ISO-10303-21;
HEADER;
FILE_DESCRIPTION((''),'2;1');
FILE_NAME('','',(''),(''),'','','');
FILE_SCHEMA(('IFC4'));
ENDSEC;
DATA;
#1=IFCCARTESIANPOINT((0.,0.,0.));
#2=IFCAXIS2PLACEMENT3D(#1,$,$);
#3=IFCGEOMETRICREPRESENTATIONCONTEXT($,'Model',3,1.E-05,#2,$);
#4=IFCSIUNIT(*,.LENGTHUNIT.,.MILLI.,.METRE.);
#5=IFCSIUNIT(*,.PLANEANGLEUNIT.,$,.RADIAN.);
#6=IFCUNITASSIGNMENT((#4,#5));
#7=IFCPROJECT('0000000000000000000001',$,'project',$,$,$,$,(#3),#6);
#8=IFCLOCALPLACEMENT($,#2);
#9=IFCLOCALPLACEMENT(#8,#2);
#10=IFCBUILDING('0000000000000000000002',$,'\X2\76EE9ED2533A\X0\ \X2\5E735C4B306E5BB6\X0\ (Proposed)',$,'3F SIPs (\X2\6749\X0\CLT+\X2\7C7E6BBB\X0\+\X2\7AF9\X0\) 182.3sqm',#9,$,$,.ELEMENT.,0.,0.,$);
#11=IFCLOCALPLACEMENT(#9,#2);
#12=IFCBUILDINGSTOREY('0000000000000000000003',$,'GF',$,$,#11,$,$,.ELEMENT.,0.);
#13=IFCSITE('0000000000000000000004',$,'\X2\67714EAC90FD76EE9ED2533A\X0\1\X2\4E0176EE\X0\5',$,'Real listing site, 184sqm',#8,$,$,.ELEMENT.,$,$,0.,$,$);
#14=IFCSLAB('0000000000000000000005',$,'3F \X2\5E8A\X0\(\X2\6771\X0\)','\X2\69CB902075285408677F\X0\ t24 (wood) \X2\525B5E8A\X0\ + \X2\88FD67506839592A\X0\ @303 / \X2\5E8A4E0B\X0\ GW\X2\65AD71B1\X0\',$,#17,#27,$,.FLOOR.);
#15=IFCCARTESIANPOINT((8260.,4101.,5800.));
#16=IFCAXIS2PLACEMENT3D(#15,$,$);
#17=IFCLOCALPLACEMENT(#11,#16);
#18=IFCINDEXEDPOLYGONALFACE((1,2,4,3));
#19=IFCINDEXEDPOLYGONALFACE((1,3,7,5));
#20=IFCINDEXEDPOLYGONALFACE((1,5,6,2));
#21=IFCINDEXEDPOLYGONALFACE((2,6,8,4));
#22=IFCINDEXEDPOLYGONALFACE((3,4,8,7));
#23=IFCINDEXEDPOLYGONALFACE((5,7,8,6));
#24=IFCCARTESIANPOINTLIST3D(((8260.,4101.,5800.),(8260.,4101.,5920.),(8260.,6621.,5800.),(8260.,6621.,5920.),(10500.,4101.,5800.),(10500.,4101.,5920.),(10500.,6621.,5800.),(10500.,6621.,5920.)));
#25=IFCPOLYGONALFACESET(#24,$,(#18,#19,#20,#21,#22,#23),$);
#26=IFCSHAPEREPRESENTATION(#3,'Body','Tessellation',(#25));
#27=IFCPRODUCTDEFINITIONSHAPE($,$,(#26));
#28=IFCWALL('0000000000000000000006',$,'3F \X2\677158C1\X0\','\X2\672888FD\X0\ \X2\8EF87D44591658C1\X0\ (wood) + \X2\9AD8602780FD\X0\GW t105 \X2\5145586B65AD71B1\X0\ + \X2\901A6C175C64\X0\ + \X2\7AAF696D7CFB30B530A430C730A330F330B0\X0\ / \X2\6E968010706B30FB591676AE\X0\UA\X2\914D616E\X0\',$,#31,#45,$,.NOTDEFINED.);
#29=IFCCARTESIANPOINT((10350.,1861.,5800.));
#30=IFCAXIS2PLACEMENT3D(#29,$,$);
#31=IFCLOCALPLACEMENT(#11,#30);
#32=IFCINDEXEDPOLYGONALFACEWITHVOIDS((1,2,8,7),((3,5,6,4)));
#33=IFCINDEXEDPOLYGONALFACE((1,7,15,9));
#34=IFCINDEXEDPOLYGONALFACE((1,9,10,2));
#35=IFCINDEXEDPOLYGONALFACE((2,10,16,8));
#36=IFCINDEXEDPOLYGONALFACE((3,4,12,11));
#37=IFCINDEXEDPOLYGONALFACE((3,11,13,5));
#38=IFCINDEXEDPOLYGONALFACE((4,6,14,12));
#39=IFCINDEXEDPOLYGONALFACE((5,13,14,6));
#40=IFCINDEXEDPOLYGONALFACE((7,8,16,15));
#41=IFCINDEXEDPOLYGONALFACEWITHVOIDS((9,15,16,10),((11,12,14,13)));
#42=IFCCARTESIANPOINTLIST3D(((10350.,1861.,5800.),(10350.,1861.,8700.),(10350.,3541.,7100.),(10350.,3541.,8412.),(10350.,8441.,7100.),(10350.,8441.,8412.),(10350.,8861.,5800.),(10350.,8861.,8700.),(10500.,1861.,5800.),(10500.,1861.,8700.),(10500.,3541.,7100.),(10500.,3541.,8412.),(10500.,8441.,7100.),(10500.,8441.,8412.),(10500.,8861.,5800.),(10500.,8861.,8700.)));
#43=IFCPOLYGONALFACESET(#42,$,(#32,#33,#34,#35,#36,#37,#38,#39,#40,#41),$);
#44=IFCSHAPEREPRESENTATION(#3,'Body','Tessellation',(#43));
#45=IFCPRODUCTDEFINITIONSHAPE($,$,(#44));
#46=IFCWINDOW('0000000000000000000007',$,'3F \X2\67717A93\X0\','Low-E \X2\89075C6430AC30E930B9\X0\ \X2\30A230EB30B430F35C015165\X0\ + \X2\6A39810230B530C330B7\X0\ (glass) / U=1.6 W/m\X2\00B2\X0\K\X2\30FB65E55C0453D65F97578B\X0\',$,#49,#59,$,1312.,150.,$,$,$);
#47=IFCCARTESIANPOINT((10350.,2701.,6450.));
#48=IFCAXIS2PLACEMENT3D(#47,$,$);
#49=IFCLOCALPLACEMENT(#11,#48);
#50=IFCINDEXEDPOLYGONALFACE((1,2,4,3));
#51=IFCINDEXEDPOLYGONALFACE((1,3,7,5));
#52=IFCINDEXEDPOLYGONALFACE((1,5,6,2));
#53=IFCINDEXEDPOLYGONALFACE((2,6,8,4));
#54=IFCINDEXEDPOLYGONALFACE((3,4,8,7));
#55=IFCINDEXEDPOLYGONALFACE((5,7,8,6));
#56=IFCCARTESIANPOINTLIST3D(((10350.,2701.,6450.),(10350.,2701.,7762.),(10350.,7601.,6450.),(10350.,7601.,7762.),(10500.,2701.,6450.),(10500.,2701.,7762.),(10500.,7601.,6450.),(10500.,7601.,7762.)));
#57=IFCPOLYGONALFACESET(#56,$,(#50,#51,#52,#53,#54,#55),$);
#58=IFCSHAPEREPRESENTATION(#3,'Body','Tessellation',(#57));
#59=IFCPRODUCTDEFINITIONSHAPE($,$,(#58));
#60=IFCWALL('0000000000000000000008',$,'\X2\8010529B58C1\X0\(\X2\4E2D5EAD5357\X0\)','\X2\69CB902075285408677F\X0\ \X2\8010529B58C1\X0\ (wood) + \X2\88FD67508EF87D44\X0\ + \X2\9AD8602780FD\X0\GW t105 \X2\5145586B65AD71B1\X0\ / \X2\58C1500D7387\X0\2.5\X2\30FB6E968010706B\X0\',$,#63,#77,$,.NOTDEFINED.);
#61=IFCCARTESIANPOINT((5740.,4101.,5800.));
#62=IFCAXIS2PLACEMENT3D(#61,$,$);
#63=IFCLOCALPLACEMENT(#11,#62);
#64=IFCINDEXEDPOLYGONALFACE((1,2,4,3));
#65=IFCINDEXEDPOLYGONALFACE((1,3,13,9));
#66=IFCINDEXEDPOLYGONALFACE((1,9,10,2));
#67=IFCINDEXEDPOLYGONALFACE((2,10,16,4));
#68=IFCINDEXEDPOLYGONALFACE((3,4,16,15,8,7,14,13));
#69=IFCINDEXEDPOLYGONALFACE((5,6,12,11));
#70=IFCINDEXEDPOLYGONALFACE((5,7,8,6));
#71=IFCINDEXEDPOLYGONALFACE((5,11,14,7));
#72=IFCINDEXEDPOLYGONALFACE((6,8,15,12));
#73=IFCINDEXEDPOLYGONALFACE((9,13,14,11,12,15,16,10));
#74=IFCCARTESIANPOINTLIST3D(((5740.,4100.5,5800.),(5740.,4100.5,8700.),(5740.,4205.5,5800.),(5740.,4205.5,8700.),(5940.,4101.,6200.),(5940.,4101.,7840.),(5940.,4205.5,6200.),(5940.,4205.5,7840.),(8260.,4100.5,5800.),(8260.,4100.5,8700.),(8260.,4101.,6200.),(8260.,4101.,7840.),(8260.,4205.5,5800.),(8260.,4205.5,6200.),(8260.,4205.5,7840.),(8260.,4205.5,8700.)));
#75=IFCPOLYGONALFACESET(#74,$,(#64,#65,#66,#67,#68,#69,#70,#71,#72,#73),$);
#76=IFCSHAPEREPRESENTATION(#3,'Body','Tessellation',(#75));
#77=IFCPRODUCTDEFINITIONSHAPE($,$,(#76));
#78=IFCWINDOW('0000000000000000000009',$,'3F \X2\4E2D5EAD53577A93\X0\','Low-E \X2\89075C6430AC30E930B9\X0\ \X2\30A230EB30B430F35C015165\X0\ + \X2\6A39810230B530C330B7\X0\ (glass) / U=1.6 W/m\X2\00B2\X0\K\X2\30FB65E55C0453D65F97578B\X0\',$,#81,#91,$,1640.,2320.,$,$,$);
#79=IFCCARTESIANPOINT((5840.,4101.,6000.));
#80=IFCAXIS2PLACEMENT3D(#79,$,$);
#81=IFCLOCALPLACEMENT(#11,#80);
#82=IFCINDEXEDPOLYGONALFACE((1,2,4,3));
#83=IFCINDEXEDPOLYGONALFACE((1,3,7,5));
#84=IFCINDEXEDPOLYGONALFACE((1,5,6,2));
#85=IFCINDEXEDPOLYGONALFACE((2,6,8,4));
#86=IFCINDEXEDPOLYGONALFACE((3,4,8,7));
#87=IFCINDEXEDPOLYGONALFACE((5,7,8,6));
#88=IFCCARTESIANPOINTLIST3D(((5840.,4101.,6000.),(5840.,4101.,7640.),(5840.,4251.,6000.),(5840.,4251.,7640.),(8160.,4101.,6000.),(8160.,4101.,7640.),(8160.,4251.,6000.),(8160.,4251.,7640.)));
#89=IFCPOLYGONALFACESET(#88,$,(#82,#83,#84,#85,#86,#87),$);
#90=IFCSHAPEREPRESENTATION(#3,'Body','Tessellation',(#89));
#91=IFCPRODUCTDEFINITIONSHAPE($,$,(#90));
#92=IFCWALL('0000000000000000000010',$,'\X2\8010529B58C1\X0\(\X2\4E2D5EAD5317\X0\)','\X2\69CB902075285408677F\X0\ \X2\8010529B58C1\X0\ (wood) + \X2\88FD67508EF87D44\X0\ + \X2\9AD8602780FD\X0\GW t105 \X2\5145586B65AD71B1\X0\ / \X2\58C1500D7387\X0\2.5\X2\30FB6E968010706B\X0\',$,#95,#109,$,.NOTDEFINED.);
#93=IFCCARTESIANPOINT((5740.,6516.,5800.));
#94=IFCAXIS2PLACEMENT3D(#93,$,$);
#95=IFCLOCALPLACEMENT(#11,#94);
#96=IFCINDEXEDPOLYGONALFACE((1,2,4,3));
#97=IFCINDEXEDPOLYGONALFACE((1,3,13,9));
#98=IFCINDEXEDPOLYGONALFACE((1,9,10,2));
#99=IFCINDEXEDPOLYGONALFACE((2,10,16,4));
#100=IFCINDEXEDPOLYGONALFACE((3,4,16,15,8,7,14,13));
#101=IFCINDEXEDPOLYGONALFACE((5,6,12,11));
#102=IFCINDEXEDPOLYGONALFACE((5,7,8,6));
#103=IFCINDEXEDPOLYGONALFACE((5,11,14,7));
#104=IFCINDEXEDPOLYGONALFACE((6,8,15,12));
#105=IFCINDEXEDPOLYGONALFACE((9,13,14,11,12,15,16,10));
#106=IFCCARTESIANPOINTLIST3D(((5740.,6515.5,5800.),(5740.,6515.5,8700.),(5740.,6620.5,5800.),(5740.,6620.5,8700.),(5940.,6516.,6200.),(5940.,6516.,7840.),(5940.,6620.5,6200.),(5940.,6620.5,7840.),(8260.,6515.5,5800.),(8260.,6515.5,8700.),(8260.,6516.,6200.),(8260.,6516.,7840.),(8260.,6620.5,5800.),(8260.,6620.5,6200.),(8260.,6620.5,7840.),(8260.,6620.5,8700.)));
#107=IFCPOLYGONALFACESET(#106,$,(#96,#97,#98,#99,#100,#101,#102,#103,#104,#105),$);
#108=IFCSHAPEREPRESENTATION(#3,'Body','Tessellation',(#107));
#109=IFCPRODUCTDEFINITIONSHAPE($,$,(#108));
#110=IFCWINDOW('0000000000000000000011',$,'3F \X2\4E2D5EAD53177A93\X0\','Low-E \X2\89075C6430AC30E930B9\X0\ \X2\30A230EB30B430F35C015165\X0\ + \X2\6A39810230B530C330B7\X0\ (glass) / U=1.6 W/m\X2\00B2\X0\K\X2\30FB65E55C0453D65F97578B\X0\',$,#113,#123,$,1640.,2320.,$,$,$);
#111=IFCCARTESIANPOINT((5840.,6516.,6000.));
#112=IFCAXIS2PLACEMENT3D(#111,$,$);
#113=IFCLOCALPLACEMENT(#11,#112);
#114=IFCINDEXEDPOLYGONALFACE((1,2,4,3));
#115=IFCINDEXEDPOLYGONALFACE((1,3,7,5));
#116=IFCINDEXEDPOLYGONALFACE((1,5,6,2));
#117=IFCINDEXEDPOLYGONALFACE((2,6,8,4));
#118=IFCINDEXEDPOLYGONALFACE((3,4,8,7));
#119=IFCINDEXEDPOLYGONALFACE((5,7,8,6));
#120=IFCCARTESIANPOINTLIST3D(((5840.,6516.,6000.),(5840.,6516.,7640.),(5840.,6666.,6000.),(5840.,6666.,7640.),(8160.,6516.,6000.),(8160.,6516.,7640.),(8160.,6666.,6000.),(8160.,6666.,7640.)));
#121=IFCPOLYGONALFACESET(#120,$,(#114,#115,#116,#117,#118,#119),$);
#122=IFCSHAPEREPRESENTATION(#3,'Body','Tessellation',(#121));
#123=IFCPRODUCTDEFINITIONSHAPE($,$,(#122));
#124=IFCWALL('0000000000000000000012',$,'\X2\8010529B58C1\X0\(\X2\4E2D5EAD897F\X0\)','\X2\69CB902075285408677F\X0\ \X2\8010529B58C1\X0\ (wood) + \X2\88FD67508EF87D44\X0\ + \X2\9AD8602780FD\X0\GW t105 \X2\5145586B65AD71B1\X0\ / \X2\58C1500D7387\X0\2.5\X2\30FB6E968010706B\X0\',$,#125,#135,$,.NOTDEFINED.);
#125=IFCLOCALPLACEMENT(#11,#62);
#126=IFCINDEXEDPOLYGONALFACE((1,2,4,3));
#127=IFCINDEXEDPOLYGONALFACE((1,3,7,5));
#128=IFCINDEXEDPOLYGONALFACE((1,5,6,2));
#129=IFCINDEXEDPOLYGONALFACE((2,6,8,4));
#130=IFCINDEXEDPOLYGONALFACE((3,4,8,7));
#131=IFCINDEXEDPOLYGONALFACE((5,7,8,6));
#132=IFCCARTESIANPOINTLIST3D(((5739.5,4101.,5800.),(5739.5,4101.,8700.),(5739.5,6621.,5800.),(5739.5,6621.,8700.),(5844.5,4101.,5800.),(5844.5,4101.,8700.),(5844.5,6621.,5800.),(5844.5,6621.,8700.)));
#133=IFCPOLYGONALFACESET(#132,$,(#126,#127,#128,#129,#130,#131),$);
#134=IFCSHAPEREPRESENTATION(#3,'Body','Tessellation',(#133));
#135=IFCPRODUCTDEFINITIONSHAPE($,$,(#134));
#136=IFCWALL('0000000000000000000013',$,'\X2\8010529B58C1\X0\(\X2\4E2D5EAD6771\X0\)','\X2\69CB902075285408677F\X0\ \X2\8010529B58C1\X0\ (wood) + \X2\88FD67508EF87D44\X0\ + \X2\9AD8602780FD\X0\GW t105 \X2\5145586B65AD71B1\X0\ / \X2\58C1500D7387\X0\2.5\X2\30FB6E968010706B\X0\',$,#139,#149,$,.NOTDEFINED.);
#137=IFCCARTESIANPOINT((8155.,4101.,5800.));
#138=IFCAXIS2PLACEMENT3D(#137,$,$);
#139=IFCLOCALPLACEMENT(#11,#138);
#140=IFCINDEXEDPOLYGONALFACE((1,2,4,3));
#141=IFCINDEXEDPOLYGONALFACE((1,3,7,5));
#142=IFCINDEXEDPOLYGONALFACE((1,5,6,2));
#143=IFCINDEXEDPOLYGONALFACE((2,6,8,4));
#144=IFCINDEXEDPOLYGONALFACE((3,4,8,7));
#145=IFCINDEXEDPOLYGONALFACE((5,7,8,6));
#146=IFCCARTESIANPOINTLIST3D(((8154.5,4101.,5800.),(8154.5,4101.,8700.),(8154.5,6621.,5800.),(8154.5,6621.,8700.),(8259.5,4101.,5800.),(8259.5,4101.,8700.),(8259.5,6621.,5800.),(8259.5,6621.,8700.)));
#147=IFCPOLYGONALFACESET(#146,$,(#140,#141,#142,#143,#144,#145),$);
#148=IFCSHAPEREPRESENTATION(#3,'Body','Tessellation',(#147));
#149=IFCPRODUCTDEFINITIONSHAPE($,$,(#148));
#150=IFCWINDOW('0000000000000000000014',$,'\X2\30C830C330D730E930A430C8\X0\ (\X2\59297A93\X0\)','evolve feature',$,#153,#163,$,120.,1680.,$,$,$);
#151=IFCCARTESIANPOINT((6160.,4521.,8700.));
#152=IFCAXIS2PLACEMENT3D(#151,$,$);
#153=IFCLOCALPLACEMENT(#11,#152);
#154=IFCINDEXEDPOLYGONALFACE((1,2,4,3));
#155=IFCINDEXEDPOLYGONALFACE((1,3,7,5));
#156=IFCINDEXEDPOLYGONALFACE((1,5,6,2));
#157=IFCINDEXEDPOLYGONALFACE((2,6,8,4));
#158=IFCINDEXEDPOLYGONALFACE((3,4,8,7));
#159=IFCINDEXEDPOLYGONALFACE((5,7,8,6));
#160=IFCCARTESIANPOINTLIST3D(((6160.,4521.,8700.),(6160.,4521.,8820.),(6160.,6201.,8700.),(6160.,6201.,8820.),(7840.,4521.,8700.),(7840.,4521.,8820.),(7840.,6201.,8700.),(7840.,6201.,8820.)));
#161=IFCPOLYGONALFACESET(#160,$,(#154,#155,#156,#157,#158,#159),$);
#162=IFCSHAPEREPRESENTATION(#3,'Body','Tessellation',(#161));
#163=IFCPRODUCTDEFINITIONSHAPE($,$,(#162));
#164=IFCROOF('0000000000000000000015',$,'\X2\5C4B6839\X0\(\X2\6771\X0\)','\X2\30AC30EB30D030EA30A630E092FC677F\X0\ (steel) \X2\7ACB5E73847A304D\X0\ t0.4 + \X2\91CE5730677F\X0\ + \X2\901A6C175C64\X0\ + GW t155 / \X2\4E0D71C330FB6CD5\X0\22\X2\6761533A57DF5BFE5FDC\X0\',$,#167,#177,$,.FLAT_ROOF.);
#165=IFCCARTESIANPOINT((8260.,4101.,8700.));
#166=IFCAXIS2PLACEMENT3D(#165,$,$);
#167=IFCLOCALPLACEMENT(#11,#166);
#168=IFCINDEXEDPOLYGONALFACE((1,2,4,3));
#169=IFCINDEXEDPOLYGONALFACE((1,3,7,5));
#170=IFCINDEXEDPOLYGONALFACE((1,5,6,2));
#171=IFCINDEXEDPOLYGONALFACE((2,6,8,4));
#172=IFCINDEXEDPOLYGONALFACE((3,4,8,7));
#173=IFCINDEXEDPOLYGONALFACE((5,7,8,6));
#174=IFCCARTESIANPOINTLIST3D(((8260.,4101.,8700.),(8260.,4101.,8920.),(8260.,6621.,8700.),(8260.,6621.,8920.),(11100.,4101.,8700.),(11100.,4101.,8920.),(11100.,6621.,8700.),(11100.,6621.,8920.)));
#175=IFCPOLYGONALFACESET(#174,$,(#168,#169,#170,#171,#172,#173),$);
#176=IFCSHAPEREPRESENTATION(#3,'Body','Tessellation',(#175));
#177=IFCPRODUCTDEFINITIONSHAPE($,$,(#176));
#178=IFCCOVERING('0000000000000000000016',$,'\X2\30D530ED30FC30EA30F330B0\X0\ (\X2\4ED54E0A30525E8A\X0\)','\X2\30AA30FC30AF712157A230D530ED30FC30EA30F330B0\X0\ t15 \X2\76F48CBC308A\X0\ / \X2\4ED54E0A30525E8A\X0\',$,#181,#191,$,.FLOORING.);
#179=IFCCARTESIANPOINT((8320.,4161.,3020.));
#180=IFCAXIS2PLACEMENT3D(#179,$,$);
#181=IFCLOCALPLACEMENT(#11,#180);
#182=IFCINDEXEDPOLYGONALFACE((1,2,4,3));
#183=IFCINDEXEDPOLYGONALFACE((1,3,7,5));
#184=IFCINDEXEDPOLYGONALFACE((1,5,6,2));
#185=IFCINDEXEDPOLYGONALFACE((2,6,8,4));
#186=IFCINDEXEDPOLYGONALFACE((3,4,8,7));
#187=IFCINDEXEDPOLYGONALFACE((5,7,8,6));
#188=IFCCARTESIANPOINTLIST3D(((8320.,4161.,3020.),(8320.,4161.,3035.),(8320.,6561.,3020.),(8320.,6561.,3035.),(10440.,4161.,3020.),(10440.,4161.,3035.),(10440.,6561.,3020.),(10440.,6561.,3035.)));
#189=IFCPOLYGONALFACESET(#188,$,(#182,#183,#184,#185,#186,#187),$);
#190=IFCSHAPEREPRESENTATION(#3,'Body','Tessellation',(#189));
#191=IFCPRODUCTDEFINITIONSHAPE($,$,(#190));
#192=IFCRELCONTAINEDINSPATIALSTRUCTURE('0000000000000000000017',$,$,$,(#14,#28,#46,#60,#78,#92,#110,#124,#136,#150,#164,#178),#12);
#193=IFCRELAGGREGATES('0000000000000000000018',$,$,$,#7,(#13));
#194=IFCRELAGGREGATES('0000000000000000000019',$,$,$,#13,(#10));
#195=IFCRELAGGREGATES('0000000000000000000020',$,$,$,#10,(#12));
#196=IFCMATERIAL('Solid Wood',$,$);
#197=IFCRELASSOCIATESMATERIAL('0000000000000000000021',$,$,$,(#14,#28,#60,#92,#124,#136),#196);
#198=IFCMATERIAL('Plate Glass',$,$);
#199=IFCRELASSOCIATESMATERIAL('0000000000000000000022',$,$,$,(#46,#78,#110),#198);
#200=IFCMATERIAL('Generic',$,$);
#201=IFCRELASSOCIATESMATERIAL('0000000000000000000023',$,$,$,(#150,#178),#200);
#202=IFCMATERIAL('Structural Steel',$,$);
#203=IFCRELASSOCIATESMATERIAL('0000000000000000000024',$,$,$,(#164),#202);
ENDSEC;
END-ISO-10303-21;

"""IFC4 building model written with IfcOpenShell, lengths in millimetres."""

from ifc_helpers import new_model, si_unit, frame, frame_2d, origin, place, context, project, spatial, rectangle, extrude, material, element, fill, save


model = new_model("IFC4")

# Units and contexts
model_context = context("Model", 3, precision=1e-05, world=origin())
ifc_project = project(units=[si_unit("LENGTHUNIT", "METRE", prefix="MILLI"), si_unit("PLANEANGLEUNIT", "RADIAN")], contexts=[model_context])

# Site, building, storey
site_placement = place(None, origin())
site = spatial("IfcSite", under=ifc_project, at=site_placement, Name="東京都目黒区1丁目5", ObjectType="Real listing site, 184sqm", CompositionType="ELEMENT", RefElevation=0.0)
building_placement = place(site_placement, origin())
building = spatial("IfcBuilding", under=site, at=building_placement, Name="目黒区 平屋の家 (Proposed)", ObjectType="3F SIPs (杉CLT+籾殻+竹) 182.3sqm", CompositionType="ELEMENT", ElevationOfRefHeight=0.0, ElevationOfTerrain=0.0)
storey_placement = place(building_placement, origin())
storey = spatial("IfcBuildingStorey", under=building, at=storey_placement, Name="GF", CompositionType="ELEMENT", Elevation=0.0)

# Slab
ifc_material_1 = material(Name="Solid Wood")
slab_placement = place(storey_placement, frame((8260.0, 4101.0, 5800.0)))
element("IfcSlab", 1, at=slab_placement, inside=storey, material=ifc_material_1, Name="3F 床(東)", Description="構造用合板 t24 (wood) 剛床 + 製材根太 @303 / 床下 GW断熱", PredefinedType="FLOOR", context=model_context, shape_type="SweptSolid", body=[
    extrude(rectangle(XDim=2240.0, YDim=2520.0, at=frame_2d((1120.0, 1260.0))), frame((8260.0, 4101.0, 5800.0)), (0.0, 0.0, 1.0), 120.0),
])

# Walls, openings, windows
wall_1_placement = place(storey_placement, frame((10350.0, 1861.0, 5800.0)))
wall_1 = element("IfcWall", 2, at=wall_1_placement, inside=storey, material=ifc_material_1, Name="3F 東壁", Description="木製 軸組外壁 (wood) + 高性能GW t105 充填断熱 + 通気層 + 窯業系サイディング / 準耐火・外皮UA配慮", PredefinedType="NOTDEFINED", context=model_context, shape_type="SweptSolid", body=[
    extrude(rectangle(XDim=150.0, YDim=7000.0, at=frame_2d((75.0, 3500.0))), frame((10350.0, 1861.0, 5800.0)), (0.0, 0.0, 1.0), 2900.0),
])
opening_1_placement = place(storey_placement, frame((10350.0, 2701.0, 6450.0)))
opening_1 = element("IfcOpeningElement", 3, at=opening_1_placement, cuts=wall_1, PredefinedType="NOTDEFINED", context=model_context, shape_type="SweptSolid", body=[
    extrude(rectangle(XDim=150.0, YDim=4900.0, at=frame_2d((75.0, 2450.0))), frame((10350.0, 2701.0, 6450.0)), (0.0, 0.0, 1.0), 1312.0),
])
ifc_material_2 = material(Name="Plate Glass")
window_1_placement = place(storey_placement, frame((10350.0, 2701.0, 6450.0)))
window_1 = element("IfcWindow", 4, at=window_1_placement, inside=storey, material=ifc_material_2, Name="3F 東窓", Description="Low-E 複層ガラス アルゴン封入 + 樹脂サッシ (glass) / U=1.6 W/m²K・日射取得型", OverallHeight=1312.0, OverallWidth=150.0, context=model_context, shape_type="SweptSolid", body=[
    extrude(rectangle(XDim=150.0, YDim=4900.0, at=frame_2d((75.0, 2450.0))), frame((10350.0, 2701.0, 6450.0)), (0.0, 0.0, 1.0), 1312.0),
])
fill(opening_1, window_1)
wall_2_placement = place(storey_placement, frame((5740.0, 4101.0, 5800.0)))
wall_2 = element("IfcWall", 5, at=wall_2_placement, inside=storey, material=ifc_material_1, Name="耐力壁(中庭南)", Description="構造用合板 耐力壁 (wood) + 製材軸組 + 高性能GW t105 充填断熱 / 壁倍率2.5・準耐火", PredefinedType="NOTDEFINED", context=model_context, shape_type="SweptSolid", body=[
    extrude(rectangle(XDim=2520.0, YDim=105.0, at=frame_2d((1260.0, 52.0))), frame((5740.0, 4101.0, 5800.0)), (0.0, 0.0, 1.0), 2900.0),
])
opening_2_placement = place(storey_placement, frame((5840.0, 4101.0, 6000.0)))
opening_2 = element("IfcOpeningElement", 6, at=opening_2_placement, cuts=wall_2, PredefinedType="NOTDEFINED", context=model_context, shape_type="SweptSolid", body=[
    extrude(rectangle(XDim=2320.0, YDim=150.0, at=frame_2d((1160.0, 75.0))), frame((5840.0, 4101.0, 6000.0)), (0.0, 0.0, 1.0), 1640.0),
])
window_2_placement = place(storey_placement, frame((5840.0, 4101.0, 6000.0)))
window_2 = element("IfcWindow", 7, at=window_2_placement, inside=storey, material=ifc_material_2, Name="3F 中庭南窓", Description="Low-E 複層ガラス アルゴン封入 + 樹脂サッシ (glass) / U=1.6 W/m²K・日射取得型", OverallHeight=1640.0, OverallWidth=2320.0, context=model_context, shape_type="SweptSolid", body=[
    extrude(rectangle(XDim=2320.0, YDim=150.0, at=frame_2d((1160.0, 75.0))), frame((5840.0, 4101.0, 6000.0)), (0.0, 0.0, 1.0), 1640.0),
])
fill(opening_2, window_2)
wall_3_placement = place(storey_placement, frame((5740.0, 6516.0, 5800.0)))
wall_3 = element("IfcWall", 8, at=wall_3_placement, inside=storey, material=ifc_material_1, Name="耐力壁(中庭北)", Description="構造用合板 耐力壁 (wood) + 製材軸組 + 高性能GW t105 充填断熱 / 壁倍率2.5・準耐火", PredefinedType="NOTDEFINED", context=model_context, shape_type="SweptSolid", body=[
    extrude(rectangle(XDim=2520.0, YDim=105.0, at=frame_2d((1260.0, 52.0))), frame((5740.0, 6516.0, 5800.0)), (0.0, 0.0, 1.0), 2900.0),
])
opening_3_placement = place(storey_placement, frame((5840.0, 6516.0, 6000.0)))
opening_3 = element("IfcOpeningElement", 9, at=opening_3_placement, cuts=wall_3, PredefinedType="NOTDEFINED", context=model_context, shape_type="SweptSolid", body=[
    extrude(rectangle(XDim=2320.0, YDim=150.0, at=frame_2d((1160.0, 75.0))), frame((5840.0, 6516.0, 6000.0)), (0.0, 0.0, 1.0), 1640.0),
])
window_3_placement = place(storey_placement, frame((5840.0, 6516.0, 6000.0)))
window_3 = element("IfcWindow", 10, at=window_3_placement, inside=storey, material=ifc_material_2, Name="3F 中庭北窓", Description="Low-E 複層ガラス アルゴン封入 + 樹脂サッシ (glass) / U=1.6 W/m²K・日射取得型", OverallHeight=1640.0, OverallWidth=2320.0, context=model_context, shape_type="SweptSolid", body=[
    extrude(rectangle(XDim=2320.0, YDim=150.0, at=frame_2d((1160.0, 75.0))), frame((5840.0, 6516.0, 6000.0)), (0.0, 0.0, 1.0), 1640.0),
])
fill(opening_3, window_3)

# Walls
wall_4_placement = place(storey_placement, frame((5740.0, 4101.0, 5800.0)))
element("IfcWall", 11, at=wall_4_placement, inside=storey, material=ifc_material_1, Name="耐力壁(中庭西)", Description="構造用合板 耐力壁 (wood) + 製材軸組 + 高性能GW t105 充填断熱 / 壁倍率2.5・準耐火", PredefinedType="NOTDEFINED", context=model_context, shape_type="SweptSolid", body=[
    extrude(rectangle(XDim=105.0, YDim=2520.0, at=frame_2d((52.0, 1260.0))), frame((5740.0, 4101.0, 5800.0)), (0.0, 0.0, 1.0), 2900.0),
])
wall_5_placement = place(storey_placement, frame((8155.0, 4101.0, 5800.0)))
element("IfcWall", 12, at=wall_5_placement, inside=storey, material=ifc_material_1, Name="耐力壁(中庭東)", Description="構造用合板 耐力壁 (wood) + 製材軸組 + 高性能GW t105 充填断熱 / 壁倍率2.5・準耐火", PredefinedType="NOTDEFINED", context=model_context, shape_type="SweptSolid", body=[
    extrude(rectangle(XDim=105.0, YDim=2520.0, at=frame_2d((52.0, 1260.0))), frame((8155.0, 4101.0, 5800.0)), (0.0, 0.0, 1.0), 2900.0),
])

# Window
ifc_material_3 = material(Name="Generic")
window_4_placement = place(storey_placement, frame((6160.0, 4521.0, 8700.0)))
element("IfcWindow", 13, at=window_4_placement, inside=storey, material=ifc_material_3, Name="トップライト (天窓)", Description="evolve feature", OverallHeight=120.0, OverallWidth=1680.0, context=model_context, shape_type="SweptSolid", body=[
    extrude(rectangle(XDim=1680.0, YDim=1680.0, at=frame_2d((840.0, 840.0))), frame((6160.0, 4521.0, 8700.0)), (0.0, 0.0, 1.0), 120.0),
])

# Roof
ifc_material_4 = material(Name="Structural Steel")
for number, where, name in (
    (14, (8260.0, 4101.0, 8700.0), "屋根(東)"),
):
    element("IfcRoof", number, at=place(storey_placement, frame(where)), inside=storey, material=ifc_material_4, Name=name, Description="ガルバリウム鋼板 (steel) 立平葺き t0.4 + 野地板 + 通気層 + GW t155 / 不燃・法22条区域対応", PredefinedType="FLAT_ROOF", context=model_context, shape_type="SweptSolid", body=[
        extrude(rectangle(XDim=2840.0, YDim=2520.0, at=frame_2d((1420.0, 1260.0))), frame((8260.0, 4101.0, 8700.0)), (0.0, 0.0, 1.0), 220.0),
    ])

# Covering
covering_1_placement = place(storey_placement, frame((8320.0, 4161.0, 3020.0)))
element("IfcCovering", 15, at=covering_1_placement, inside=storey, material=ifc_material_3, Name="フローリング (仕上げ床)", Description="オーク無垢フローリング t15 直貼り / 仕上げ床", PredefinedType="FLOORING", context=model_context, shape_type="SweptSolid", body=[
    extrude(rectangle(XDim=2120.0, YDim=2400.0, at=frame_2d((1060.0, 1200.0))), frame((8320.0, 4161.0, 3020.0)), (0.0, 0.0, 1.0), 15.0),
])

save(model, "model.ifc")
